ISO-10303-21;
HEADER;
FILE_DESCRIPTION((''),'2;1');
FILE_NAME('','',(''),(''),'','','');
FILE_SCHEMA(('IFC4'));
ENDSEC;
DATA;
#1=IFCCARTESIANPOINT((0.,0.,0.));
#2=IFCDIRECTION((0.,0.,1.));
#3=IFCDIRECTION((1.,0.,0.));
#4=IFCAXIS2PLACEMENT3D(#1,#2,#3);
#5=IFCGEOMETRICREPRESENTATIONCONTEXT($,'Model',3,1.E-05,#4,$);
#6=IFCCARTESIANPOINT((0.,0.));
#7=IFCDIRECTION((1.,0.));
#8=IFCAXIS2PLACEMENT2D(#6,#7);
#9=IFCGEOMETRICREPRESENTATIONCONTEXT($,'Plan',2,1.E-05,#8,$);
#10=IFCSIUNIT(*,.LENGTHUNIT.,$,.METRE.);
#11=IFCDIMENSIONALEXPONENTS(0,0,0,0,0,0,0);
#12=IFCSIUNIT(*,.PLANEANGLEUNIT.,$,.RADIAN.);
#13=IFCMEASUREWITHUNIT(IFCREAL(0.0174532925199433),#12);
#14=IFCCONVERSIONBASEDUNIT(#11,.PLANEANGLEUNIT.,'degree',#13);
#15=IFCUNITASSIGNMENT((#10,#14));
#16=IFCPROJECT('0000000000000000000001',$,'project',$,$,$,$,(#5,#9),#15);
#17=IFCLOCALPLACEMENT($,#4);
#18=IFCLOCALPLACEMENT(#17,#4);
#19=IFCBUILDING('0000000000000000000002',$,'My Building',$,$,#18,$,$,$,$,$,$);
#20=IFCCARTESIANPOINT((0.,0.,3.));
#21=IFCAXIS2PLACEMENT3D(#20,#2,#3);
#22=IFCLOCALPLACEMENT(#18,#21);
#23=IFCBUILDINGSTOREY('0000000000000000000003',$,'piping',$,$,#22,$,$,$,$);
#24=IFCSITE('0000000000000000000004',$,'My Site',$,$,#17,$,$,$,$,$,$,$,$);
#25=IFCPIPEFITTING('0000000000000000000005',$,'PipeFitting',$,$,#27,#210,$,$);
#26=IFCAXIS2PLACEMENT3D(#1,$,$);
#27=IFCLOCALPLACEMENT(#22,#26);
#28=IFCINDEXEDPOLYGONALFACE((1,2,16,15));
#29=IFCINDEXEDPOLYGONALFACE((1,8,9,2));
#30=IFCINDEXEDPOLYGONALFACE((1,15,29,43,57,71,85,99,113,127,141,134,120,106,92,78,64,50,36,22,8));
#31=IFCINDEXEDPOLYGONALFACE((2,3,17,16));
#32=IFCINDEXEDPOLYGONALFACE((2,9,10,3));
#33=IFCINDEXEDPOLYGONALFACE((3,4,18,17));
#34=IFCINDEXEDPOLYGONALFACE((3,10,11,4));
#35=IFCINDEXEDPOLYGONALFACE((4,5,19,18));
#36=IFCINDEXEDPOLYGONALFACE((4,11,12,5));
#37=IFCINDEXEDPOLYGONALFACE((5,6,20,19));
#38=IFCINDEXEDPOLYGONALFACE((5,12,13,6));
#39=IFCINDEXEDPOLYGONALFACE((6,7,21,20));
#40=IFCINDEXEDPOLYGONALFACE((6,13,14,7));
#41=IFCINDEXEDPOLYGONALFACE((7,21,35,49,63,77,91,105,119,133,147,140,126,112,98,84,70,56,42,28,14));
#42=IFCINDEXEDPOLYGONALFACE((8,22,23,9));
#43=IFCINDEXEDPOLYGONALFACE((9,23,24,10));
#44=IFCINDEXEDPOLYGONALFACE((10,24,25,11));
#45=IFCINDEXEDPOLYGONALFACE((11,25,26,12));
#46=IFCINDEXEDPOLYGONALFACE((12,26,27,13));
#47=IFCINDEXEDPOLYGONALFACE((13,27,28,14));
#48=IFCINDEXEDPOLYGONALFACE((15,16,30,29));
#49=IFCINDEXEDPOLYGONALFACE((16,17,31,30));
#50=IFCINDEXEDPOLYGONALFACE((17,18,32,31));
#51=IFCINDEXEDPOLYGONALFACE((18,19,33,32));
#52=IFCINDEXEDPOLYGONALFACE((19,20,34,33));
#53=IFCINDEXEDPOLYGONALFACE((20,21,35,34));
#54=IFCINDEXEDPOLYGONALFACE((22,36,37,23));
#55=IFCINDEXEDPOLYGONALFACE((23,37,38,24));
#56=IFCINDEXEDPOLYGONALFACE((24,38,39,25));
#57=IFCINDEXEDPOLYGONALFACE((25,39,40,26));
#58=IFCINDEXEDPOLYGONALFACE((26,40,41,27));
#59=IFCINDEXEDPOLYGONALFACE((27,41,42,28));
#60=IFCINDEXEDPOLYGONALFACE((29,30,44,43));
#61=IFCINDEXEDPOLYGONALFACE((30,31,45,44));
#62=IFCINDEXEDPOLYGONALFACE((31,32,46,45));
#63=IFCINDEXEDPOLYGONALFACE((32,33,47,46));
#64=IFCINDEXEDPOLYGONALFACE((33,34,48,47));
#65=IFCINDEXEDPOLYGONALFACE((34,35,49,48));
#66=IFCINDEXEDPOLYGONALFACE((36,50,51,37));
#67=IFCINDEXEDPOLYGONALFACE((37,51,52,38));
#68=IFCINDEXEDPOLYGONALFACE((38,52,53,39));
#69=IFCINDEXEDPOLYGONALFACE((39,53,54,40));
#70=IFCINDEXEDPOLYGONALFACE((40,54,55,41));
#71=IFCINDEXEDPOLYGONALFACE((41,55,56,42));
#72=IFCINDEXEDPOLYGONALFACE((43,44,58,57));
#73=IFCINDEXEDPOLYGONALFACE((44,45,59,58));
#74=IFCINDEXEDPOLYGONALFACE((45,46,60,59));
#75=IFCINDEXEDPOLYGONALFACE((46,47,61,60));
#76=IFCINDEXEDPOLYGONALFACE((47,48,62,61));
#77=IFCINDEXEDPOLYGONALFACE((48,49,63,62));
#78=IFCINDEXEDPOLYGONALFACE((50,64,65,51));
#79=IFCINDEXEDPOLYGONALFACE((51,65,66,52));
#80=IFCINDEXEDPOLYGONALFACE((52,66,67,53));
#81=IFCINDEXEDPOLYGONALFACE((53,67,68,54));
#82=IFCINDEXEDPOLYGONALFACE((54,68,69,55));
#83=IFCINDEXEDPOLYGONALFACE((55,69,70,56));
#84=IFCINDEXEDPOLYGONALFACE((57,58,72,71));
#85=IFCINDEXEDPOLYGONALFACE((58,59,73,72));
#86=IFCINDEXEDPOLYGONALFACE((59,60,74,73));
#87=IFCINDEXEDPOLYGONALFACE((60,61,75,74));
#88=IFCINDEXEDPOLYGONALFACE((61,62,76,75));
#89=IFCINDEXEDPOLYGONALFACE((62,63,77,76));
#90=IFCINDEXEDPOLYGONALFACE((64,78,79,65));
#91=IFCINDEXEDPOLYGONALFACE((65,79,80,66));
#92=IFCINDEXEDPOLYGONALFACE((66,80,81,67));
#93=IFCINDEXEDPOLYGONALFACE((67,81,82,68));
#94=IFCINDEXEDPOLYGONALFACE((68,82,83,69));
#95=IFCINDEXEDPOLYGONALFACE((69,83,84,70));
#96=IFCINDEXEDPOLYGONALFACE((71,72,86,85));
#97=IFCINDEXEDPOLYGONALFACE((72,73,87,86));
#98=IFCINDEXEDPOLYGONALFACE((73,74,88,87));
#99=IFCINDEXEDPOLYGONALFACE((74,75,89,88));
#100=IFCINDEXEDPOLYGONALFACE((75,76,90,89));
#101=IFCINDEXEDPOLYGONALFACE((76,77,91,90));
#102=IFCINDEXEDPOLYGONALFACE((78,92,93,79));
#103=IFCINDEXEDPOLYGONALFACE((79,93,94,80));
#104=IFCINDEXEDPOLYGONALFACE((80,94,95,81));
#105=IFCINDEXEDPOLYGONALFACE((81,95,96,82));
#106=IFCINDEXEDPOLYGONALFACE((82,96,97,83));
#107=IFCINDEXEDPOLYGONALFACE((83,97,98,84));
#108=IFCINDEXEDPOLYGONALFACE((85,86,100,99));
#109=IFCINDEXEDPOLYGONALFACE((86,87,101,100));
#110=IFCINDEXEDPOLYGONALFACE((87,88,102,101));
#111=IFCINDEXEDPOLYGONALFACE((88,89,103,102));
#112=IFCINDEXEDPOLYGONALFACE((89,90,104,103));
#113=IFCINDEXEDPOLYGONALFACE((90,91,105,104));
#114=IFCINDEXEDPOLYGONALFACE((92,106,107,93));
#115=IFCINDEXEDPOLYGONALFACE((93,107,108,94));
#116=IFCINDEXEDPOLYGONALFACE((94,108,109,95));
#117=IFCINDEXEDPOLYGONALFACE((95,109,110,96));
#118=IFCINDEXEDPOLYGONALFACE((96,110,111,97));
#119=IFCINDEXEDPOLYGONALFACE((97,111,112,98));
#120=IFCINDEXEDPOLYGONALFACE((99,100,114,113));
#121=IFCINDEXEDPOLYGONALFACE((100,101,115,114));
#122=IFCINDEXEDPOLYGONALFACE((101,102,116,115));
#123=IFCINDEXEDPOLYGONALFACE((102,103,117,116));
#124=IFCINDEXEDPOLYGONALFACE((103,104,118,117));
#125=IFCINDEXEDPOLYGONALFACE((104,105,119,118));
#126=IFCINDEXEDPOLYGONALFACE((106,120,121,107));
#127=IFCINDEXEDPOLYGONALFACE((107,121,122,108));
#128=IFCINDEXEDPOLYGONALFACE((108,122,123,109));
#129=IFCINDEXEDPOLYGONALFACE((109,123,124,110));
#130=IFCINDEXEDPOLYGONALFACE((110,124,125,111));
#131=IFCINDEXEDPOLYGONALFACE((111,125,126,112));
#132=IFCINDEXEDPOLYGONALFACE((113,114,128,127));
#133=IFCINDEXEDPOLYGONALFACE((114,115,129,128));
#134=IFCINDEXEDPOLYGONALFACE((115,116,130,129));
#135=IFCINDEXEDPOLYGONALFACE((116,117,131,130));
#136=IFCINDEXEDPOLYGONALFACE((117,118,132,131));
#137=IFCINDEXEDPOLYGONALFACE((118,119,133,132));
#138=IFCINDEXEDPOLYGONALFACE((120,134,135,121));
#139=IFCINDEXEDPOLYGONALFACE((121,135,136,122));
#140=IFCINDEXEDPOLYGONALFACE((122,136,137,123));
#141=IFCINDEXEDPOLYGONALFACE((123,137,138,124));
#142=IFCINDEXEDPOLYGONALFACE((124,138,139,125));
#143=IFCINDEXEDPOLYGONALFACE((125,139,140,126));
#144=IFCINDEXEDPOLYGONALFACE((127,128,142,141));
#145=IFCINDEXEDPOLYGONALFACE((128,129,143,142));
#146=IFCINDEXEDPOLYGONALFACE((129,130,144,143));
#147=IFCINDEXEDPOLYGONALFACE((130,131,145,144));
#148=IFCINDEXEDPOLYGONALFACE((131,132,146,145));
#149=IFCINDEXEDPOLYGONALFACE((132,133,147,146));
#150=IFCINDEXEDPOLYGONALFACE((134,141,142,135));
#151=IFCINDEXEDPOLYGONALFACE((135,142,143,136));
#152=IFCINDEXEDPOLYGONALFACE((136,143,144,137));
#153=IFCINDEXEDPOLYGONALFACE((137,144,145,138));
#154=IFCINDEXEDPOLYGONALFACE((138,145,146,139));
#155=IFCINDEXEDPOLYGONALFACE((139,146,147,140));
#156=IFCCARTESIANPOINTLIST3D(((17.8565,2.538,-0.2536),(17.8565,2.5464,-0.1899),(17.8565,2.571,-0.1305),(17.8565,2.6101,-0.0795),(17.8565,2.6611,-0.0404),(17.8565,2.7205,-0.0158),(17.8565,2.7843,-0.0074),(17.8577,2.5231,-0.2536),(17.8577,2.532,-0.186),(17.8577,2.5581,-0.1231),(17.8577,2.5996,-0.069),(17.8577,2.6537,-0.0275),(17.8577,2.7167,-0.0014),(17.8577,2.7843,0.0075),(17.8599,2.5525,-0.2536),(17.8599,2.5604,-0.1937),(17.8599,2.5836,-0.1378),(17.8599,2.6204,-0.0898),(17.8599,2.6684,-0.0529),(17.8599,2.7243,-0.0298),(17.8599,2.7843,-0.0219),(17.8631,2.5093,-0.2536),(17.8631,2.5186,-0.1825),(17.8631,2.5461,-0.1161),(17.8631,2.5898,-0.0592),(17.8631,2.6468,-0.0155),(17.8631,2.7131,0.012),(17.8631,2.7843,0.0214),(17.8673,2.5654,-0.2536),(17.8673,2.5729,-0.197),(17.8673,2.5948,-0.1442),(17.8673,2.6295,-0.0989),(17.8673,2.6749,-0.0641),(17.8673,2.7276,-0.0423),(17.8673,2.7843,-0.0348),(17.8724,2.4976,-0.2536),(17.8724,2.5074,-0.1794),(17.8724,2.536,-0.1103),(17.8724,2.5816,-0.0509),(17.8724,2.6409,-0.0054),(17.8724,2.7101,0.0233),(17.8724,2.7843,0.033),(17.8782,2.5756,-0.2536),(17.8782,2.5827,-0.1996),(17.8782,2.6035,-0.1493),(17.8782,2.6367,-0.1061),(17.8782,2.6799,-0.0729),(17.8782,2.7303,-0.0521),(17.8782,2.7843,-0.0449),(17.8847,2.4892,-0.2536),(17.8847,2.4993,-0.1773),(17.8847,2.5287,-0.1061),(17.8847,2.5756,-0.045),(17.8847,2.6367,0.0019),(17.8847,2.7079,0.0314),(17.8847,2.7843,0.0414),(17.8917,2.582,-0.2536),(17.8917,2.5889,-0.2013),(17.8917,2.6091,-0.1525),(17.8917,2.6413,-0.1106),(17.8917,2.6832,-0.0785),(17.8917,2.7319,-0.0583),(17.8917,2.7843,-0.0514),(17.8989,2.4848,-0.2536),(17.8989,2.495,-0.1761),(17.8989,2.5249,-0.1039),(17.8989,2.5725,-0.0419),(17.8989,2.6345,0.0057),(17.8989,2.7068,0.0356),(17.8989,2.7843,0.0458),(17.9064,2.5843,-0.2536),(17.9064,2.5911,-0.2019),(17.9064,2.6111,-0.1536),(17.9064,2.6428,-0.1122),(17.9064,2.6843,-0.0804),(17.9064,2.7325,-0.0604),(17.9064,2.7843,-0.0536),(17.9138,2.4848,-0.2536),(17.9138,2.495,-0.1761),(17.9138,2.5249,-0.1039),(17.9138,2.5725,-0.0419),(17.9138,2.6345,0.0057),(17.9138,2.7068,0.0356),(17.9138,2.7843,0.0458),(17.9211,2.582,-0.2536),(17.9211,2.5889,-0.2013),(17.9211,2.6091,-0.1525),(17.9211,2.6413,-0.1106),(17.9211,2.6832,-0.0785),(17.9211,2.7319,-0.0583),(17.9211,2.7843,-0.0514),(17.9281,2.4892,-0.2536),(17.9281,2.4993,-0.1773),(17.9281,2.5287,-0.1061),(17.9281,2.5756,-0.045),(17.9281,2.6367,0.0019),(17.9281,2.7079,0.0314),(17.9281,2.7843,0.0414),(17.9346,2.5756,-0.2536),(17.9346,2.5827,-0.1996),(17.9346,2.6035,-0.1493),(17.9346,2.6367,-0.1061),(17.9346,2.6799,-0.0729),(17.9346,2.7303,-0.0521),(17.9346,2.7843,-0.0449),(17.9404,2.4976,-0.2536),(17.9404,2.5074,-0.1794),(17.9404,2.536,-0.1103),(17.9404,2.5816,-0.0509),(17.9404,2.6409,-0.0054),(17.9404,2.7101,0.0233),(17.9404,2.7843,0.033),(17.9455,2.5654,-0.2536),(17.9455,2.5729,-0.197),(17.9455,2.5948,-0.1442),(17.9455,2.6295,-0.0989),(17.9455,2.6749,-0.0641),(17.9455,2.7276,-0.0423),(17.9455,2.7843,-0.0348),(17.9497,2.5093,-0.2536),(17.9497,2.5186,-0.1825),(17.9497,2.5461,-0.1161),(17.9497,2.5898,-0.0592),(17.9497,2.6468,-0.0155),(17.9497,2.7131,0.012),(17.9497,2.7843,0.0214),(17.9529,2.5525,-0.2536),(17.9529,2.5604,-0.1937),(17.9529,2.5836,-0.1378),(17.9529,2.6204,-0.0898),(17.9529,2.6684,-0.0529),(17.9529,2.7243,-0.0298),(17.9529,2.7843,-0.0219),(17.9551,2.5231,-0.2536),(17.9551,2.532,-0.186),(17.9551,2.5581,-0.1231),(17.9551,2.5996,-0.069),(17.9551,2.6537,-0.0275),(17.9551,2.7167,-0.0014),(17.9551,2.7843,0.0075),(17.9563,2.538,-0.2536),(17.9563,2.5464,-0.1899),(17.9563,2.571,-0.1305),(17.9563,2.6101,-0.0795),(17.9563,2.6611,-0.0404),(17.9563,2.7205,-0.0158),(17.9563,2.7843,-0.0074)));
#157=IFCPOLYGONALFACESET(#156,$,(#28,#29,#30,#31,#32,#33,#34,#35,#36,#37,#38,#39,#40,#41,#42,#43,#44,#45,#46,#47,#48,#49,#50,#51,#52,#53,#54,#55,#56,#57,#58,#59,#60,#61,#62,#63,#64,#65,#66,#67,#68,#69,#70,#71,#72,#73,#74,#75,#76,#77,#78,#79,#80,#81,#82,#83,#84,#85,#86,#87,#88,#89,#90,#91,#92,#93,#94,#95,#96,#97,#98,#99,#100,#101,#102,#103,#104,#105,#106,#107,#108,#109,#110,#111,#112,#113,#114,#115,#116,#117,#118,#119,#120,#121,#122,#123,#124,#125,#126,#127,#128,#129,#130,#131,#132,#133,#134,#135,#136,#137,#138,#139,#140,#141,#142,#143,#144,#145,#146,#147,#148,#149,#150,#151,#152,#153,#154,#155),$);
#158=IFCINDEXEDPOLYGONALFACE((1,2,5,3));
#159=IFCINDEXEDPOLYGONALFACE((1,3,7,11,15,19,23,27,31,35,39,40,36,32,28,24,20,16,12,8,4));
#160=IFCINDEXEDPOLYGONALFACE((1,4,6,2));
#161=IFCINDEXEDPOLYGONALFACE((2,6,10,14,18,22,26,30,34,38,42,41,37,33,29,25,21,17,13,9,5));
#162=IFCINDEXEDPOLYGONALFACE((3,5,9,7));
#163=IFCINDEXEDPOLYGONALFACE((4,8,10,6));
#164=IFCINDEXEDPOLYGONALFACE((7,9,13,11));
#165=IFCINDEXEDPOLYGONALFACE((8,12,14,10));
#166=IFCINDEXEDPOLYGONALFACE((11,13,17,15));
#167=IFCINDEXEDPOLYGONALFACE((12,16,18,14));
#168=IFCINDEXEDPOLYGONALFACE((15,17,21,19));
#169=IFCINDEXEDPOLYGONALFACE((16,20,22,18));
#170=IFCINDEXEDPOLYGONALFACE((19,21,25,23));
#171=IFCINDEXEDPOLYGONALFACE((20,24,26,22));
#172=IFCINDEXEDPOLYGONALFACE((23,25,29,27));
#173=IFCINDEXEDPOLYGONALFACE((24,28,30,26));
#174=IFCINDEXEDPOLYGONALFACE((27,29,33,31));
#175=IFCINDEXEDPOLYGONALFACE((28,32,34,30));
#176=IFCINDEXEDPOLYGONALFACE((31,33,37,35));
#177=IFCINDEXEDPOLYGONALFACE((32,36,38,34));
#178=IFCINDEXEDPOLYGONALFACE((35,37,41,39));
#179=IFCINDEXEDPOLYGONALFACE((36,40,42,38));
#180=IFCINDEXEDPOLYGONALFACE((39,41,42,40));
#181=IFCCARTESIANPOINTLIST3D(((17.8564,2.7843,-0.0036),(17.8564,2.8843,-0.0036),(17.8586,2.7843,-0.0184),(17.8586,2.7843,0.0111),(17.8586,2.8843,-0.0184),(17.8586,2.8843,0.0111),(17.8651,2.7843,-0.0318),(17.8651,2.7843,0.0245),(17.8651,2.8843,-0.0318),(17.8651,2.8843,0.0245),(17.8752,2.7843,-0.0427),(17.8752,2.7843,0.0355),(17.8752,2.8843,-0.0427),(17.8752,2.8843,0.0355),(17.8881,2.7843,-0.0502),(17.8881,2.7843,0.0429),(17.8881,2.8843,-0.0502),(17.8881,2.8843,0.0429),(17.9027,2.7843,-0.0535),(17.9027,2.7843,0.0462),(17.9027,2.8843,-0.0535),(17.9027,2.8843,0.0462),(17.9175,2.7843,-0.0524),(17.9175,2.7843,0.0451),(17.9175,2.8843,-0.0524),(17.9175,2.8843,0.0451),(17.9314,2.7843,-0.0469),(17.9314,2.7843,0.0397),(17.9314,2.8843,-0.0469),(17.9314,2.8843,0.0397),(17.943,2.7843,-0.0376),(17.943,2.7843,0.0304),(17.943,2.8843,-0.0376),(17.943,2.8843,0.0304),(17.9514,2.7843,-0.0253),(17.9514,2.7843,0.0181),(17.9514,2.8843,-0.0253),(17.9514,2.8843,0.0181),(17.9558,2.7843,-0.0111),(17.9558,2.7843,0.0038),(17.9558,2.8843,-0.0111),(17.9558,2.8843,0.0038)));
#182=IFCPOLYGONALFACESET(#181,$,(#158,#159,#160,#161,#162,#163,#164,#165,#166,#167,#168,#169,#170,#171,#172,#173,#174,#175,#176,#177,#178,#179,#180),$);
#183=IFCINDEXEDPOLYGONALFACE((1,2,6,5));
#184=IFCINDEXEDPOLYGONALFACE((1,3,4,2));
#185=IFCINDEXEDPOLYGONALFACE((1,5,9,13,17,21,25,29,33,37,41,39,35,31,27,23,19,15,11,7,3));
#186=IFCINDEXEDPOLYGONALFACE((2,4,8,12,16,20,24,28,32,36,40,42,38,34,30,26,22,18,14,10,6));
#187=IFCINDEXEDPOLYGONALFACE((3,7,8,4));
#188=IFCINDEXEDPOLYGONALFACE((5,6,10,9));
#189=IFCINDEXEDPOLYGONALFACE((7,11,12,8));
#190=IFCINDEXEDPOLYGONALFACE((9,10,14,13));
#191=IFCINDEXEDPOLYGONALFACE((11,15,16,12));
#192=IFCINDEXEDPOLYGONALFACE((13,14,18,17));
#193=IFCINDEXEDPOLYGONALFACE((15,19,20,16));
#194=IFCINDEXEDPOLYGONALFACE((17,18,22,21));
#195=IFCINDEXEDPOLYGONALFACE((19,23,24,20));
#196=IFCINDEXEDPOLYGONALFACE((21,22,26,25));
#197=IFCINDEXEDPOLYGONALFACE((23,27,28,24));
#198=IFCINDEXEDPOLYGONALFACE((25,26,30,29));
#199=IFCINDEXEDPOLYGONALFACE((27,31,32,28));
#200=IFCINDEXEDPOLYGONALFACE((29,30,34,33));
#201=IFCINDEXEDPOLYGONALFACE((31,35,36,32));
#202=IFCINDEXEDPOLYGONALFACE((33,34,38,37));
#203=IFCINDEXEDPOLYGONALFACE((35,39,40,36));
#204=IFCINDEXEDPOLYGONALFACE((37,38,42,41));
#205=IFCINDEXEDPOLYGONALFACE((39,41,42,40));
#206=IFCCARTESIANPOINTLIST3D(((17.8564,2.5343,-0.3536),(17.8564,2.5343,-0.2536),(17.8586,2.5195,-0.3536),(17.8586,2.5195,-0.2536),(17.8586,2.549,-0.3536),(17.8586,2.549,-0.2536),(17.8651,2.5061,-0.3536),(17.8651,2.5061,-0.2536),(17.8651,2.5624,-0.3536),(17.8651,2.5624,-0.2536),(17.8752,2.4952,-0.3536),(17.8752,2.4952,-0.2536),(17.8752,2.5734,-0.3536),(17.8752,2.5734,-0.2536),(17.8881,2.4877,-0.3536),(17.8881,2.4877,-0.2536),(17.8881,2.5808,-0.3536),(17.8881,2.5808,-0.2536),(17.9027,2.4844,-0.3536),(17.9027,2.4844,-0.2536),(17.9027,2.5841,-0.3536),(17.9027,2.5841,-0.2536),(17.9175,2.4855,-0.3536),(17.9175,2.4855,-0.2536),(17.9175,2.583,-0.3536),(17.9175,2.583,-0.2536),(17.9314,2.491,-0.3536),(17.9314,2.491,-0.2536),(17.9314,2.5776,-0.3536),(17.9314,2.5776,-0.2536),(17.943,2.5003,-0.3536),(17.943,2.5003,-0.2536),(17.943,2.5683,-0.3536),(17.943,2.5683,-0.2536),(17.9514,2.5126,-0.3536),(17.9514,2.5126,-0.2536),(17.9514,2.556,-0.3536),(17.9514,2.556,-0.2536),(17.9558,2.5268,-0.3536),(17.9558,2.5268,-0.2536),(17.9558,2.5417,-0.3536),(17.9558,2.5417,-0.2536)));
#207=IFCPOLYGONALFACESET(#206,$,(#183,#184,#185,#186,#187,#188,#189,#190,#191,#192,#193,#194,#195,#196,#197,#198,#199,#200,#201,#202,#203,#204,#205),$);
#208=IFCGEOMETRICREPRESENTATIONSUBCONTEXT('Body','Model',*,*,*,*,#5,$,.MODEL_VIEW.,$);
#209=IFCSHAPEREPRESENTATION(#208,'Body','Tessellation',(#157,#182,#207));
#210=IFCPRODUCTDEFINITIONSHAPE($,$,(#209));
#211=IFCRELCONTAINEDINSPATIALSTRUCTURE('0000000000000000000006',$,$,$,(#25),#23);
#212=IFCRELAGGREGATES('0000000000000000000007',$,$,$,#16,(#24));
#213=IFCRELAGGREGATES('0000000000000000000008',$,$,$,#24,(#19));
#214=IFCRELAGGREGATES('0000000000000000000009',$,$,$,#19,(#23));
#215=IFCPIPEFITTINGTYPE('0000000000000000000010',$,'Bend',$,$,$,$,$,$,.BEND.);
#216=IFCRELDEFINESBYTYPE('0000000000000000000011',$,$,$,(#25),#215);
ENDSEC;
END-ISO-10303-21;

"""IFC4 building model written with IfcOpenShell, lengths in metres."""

from ifc_helpers import new_model, entity, si_unit, converted_unit, frame, origin_with_axes, origin_2d_with_axis, place, context, subcontext, project, spatial, circle, extrude, source, transform, mapped, type_object, type_shapes, element, save


model = new_model("IFC4")

# Units and contexts
model_context = context("Model", 3, precision=1e-05, world=origin_with_axes())
plan_context = context("Plan", 2, precision=1e-05, world=origin_2d_with_axis())
body_context = subcontext(model_context, "Body", "Model", "MODEL_VIEW")
ifc_project = project(units=[si_unit("LENGTHUNIT", "METRE"), converted_unit("PLANEANGLEUNIT", "degree", entity("IfcReal", 0.0174532925199433), si_unit("PLANEANGLEUNIT", "RADIAN"), dimensions=[0, 0, 0, 0, 0, 0, 0])], contexts=[model_context, plan_context])

# Site, building, storey
site_placement = place(None, origin_with_axes())
site = spatial("IfcSite", under=ifc_project, at=site_placement, Name="My Site")
building_placement = place(site_placement, origin_with_axes())
building = spatial("IfcBuilding", under=site, at=building_placement, Name="My Building")
storey_placement = place(building_placement, frame((0.0, 0.0, 3.0), z_axis=(0.0, 0.0, 1.0), x_axis=(1.0, 0.0, 0.0)))
storey = spatial("IfcBuildingStorey", under=building, at=storey_placement, Name="piping")

# Pipe fitting
pipe_fitting_type = type_object("IfcPipeFittingType", Name="Bend", PredefinedType="BEND")
shared_shape = source(origin_with_axes(), body_context, "Body", "SolidModel", [
    entity("IfcSweptDiskSolid", entity("IfcIndexedPolyCurve", entity("IfcCartesianPointList3D", [[0.0, 0.0, -0.1], [0.0, -0.0732, -0.2768], [0.0, -0.25, -0.35]]), [entity("IfcArcIndex", [1, 2, 3])]), 0.05),
    extrude(circle(Radius=0.05), origin_with_axes(), (0.0, 0.0, -1.0), 0.1),
    extrude(circle(Radius=0.05), frame((0.0, -0.25, -0.35), z_axis=(0.0, -1.0, 0.0), x_axis=(1.0, 0.0, 0.0)), (0.0, 0.0, 1.0), 0.1),
])
type_shapes(pipe_fitting_type, [shared_shape])
for number, where, z_axis, x_axis, name in (
    (1, (17.9064, 2.8843, -0.0036), (0.0, 1.0, 0.0), (-1.0, 0.0, 0.0), "PipeFitting"),
):
    element("IfcPipeFitting", number, at=place(storey_placement, frame(where, z_axis=z_axis, x_axis=x_axis)), inside=storey, type_object=pipe_fitting_type, Name=name, context=body_context, shape_type="MappedRepresentation", body=[
        mapped(shared_shape, transform((0.0, 0.0, 0.0), x_axis=(1.0, 0.0, 0.0), y_axis=(0.0, 1.0, 0.0), z_axis=(0.0, 0.0, 1.0), scale=1.0)),
    ])

save(model, "model.ifc")
